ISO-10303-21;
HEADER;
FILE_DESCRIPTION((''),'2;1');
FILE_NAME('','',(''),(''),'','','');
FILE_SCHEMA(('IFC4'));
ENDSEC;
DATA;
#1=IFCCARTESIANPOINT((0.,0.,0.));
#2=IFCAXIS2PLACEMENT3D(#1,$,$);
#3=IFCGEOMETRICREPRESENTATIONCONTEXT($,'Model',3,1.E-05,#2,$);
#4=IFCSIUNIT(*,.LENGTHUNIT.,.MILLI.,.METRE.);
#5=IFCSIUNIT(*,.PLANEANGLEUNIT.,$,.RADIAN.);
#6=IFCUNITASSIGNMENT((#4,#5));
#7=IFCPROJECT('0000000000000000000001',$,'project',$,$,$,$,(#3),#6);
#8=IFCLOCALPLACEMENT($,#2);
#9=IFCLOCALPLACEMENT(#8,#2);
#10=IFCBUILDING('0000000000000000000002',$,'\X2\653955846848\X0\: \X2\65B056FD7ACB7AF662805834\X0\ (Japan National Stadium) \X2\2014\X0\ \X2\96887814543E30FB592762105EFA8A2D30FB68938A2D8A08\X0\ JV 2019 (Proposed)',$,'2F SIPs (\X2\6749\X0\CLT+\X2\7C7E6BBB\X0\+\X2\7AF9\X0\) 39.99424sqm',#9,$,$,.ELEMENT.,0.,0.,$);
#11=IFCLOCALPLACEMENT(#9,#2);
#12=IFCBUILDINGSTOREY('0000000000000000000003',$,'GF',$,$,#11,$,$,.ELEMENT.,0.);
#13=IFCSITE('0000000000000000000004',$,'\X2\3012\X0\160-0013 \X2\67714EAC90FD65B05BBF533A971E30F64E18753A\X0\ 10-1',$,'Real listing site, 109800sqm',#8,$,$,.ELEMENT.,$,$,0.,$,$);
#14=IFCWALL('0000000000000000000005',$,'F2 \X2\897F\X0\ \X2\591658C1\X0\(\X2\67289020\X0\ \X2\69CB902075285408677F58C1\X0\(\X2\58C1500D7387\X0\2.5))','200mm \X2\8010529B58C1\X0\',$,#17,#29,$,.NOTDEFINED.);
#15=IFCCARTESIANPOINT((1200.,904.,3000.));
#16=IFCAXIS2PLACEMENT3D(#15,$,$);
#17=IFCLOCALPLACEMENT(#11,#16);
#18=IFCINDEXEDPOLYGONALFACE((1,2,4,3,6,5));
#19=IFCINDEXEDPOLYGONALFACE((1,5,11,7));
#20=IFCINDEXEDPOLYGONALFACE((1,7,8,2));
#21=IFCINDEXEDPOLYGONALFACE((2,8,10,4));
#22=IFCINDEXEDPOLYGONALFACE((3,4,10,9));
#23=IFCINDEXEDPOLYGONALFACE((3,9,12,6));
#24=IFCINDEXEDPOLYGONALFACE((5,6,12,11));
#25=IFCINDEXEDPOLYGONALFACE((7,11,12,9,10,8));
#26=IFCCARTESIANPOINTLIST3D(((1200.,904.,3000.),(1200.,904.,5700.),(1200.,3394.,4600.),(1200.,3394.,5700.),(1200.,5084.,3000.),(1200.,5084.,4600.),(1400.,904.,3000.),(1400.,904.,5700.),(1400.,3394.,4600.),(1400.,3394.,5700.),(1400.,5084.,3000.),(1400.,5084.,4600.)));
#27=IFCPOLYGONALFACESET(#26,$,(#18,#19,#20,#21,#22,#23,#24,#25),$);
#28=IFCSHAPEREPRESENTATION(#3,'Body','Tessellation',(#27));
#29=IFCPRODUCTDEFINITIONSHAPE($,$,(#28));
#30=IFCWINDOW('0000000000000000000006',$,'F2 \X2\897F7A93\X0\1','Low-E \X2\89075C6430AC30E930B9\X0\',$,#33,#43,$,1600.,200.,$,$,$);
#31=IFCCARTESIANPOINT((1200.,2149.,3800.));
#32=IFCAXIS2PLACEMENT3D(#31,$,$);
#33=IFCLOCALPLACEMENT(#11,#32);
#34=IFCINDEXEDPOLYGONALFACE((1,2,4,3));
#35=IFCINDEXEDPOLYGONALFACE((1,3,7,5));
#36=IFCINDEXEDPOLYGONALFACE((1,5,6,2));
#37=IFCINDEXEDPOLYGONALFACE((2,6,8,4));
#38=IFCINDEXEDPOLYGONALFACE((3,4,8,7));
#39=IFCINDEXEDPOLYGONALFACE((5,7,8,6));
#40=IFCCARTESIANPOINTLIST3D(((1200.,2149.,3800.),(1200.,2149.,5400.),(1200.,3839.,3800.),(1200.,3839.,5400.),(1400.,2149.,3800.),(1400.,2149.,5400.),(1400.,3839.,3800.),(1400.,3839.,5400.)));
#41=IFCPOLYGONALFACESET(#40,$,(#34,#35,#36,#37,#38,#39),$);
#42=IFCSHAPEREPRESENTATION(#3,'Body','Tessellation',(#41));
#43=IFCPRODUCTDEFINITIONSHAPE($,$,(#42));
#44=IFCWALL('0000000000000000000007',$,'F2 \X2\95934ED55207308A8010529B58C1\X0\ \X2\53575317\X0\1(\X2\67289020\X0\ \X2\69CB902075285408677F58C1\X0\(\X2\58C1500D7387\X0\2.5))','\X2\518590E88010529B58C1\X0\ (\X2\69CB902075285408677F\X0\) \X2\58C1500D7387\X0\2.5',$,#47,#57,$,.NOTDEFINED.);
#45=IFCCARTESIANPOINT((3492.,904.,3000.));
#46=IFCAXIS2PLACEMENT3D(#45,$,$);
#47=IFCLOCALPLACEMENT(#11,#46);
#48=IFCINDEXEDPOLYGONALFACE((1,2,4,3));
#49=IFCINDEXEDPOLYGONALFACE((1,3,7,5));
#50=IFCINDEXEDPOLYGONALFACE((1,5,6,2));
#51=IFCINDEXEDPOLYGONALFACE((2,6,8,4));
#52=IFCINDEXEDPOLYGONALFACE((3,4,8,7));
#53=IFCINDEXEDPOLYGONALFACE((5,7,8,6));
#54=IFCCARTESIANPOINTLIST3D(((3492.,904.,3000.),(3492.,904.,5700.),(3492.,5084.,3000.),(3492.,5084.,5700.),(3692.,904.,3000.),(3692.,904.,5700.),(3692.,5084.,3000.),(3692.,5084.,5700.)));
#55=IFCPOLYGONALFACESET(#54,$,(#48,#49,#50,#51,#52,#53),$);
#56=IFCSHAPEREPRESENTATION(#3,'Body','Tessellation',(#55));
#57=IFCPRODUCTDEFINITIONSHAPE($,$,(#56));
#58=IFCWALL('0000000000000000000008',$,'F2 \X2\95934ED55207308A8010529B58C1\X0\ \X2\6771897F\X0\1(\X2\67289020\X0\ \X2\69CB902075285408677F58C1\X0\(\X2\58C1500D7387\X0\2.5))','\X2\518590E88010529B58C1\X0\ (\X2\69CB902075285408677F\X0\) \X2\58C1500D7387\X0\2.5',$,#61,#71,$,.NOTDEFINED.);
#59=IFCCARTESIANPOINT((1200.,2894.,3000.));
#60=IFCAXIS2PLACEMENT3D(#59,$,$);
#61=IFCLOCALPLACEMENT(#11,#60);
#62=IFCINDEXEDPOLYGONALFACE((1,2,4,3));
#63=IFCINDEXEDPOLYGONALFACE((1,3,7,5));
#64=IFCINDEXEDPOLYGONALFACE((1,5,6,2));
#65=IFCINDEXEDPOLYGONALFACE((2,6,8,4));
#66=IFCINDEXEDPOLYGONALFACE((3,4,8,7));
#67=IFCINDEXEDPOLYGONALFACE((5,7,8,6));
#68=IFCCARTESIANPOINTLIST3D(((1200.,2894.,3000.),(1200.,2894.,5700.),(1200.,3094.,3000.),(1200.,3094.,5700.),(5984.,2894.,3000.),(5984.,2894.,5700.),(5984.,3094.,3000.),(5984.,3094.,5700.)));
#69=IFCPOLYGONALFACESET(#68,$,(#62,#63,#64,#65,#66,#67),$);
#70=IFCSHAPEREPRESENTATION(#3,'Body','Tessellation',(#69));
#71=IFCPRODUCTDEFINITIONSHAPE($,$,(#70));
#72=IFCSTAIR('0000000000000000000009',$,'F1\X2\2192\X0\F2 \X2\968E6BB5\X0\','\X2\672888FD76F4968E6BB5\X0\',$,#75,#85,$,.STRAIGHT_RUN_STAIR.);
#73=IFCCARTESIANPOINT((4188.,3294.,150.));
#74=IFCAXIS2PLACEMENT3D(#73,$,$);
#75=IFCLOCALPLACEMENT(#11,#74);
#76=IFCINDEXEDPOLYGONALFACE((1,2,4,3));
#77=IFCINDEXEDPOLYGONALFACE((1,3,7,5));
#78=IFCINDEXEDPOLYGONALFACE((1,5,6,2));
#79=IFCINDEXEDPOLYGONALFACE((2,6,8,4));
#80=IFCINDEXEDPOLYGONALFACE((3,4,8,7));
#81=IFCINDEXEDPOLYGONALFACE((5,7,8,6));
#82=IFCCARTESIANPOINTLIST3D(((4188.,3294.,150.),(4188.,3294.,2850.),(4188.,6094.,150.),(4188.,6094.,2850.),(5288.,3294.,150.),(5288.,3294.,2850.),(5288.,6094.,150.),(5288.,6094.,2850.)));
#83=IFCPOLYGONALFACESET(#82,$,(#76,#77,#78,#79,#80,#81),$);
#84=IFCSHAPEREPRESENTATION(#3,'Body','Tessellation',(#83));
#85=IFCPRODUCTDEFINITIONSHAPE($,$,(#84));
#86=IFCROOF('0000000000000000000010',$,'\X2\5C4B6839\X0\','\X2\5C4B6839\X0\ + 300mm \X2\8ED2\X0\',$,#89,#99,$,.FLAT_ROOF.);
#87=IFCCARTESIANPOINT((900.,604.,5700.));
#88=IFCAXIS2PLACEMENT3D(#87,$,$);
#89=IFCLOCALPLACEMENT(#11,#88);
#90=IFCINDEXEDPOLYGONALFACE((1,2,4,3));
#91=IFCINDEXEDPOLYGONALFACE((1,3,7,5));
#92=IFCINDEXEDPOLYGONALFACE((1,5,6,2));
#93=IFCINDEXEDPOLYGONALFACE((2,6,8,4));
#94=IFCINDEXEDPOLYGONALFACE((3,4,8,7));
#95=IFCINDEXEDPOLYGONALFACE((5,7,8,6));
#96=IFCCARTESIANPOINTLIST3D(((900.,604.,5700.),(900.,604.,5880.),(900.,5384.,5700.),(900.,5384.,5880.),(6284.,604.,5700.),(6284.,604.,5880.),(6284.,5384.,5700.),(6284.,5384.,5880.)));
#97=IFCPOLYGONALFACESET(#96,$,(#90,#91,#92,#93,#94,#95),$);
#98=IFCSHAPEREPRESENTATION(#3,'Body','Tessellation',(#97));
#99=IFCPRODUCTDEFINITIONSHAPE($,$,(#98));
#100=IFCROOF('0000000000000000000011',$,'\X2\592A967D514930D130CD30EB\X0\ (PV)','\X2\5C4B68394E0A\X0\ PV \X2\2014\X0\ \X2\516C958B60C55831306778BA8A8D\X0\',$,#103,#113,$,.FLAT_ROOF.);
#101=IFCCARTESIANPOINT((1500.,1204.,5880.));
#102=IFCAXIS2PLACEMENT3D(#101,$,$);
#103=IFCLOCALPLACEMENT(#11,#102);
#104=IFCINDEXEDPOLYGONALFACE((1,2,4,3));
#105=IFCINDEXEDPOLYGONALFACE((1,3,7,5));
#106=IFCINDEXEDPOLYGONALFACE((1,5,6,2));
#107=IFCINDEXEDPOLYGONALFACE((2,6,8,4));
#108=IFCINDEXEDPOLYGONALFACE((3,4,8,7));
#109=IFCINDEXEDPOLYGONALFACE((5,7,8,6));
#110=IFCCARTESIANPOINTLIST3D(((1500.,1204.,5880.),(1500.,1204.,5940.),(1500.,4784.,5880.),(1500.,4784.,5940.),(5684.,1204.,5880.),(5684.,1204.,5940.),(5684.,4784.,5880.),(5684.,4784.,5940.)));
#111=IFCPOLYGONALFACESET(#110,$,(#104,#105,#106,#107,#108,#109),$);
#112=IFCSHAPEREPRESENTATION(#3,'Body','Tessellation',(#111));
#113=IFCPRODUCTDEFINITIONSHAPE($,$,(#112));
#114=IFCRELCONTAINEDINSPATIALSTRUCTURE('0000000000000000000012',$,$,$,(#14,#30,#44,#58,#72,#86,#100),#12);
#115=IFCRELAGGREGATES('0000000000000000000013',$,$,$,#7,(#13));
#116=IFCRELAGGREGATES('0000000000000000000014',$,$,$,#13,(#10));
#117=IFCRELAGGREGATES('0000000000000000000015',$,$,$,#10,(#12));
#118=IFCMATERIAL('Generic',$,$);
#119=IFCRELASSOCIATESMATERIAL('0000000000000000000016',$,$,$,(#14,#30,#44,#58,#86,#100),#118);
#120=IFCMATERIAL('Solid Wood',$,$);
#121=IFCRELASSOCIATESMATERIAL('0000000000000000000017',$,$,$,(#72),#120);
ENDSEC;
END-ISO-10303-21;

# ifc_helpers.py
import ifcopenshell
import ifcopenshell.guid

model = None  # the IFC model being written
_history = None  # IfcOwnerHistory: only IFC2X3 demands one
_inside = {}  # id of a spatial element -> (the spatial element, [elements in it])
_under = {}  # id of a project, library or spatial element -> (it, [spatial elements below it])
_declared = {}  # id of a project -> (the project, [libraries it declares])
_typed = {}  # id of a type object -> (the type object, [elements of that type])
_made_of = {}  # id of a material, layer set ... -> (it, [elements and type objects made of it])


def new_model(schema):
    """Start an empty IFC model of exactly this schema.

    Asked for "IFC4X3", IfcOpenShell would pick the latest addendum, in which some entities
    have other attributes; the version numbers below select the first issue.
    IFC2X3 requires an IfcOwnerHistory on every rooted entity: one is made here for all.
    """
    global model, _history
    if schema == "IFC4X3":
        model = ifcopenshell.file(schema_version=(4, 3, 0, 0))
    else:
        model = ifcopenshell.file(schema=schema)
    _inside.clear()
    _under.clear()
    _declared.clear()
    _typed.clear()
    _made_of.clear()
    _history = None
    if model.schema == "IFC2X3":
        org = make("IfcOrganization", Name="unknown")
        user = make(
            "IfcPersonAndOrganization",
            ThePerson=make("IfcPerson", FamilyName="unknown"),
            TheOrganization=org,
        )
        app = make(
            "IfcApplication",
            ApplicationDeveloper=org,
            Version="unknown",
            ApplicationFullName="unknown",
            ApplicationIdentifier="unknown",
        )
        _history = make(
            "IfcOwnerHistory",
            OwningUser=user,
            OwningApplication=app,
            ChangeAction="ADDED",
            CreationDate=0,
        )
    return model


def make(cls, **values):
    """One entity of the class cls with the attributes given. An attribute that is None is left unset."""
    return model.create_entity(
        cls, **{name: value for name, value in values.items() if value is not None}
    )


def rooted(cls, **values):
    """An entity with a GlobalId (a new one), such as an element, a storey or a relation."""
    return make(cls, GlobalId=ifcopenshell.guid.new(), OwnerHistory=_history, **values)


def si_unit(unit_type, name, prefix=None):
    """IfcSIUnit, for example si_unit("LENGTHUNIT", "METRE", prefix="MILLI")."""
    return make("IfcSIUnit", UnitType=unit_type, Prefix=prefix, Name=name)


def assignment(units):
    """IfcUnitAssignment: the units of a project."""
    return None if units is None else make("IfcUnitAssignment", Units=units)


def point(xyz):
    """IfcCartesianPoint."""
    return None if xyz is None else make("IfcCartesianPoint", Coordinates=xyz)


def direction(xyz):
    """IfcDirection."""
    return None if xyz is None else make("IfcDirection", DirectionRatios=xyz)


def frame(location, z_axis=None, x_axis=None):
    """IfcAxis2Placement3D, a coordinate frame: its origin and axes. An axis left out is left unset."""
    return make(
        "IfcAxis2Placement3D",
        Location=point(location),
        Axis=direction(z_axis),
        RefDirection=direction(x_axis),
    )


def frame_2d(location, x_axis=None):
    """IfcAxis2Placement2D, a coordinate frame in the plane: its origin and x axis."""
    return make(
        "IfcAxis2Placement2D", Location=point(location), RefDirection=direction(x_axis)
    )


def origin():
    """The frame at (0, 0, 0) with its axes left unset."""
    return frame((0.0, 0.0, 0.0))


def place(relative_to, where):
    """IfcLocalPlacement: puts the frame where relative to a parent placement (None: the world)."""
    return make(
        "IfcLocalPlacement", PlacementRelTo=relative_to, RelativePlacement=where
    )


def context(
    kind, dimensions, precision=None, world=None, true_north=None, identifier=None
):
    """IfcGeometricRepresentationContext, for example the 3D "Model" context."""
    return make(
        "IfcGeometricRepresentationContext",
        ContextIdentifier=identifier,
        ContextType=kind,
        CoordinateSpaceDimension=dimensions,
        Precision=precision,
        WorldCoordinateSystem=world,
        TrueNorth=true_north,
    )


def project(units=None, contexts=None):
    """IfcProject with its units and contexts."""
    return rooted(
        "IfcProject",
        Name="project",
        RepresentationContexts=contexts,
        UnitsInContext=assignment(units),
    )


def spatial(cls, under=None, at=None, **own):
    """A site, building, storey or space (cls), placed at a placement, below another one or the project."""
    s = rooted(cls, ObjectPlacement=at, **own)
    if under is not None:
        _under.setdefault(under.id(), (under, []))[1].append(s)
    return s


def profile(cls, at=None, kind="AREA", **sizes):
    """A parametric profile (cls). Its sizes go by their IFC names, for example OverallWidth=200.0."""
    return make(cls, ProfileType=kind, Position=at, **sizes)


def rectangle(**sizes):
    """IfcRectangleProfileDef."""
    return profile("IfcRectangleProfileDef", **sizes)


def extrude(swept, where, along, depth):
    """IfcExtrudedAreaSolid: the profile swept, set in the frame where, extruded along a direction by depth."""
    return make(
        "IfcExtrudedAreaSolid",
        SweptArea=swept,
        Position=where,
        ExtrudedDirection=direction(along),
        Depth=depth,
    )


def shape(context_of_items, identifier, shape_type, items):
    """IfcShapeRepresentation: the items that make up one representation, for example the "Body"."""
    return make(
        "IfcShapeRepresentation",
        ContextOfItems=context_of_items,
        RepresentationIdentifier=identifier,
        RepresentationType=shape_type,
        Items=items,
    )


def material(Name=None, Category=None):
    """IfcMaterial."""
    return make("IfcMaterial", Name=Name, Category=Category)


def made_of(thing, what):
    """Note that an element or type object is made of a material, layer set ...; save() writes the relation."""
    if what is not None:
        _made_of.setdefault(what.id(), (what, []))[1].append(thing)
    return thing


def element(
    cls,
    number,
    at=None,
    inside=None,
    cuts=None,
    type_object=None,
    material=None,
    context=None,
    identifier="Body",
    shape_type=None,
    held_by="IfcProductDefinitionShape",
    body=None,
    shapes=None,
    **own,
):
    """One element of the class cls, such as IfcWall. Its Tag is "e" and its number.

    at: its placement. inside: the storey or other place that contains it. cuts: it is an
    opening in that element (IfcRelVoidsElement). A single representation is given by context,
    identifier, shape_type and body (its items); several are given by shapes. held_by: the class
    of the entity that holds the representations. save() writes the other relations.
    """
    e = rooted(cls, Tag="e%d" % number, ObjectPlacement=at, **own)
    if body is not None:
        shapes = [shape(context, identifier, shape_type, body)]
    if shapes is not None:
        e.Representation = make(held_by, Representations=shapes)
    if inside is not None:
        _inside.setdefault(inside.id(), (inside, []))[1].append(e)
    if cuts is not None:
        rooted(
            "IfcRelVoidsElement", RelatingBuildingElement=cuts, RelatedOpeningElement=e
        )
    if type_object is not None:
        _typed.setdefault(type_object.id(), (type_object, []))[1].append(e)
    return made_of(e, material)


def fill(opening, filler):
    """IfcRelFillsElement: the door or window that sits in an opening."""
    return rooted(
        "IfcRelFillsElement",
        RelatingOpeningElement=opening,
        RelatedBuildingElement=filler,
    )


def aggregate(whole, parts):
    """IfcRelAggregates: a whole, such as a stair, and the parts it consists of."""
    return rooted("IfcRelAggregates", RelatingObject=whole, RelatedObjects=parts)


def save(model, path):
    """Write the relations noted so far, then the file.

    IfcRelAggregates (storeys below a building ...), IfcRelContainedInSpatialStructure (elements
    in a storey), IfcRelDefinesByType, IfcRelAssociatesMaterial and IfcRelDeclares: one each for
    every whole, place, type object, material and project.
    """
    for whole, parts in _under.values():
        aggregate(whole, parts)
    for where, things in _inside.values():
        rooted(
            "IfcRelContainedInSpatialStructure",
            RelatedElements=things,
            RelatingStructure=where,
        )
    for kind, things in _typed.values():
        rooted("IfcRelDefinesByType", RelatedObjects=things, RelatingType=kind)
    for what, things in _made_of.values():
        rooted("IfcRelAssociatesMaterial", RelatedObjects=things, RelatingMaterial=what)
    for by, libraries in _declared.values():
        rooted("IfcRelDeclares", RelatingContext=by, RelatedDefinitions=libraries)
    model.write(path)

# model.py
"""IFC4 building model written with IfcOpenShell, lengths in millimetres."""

from ifc_helpers import new_model, si_unit, frame, frame_2d, origin, place, context, project, spatial, rectangle, extrude, material, element, fill, save


model = new_model("IFC4")

# Units and contexts
model_context = context("Model", 3, precision=1e-05, world=origin())
ifc_project = project(units=[si_unit("LENGTHUNIT", "METRE", prefix="MILLI"), si_unit("PLANEANGLEUNIT", "RADIAN")], contexts=[model_context])

# Site, building, storey
site_placement = place(None, origin())
site = spatial("IfcSite", under=ifc_project, at=site_placement, Name="〒160-0013 東京都新宿区霞ヶ丘町 10-1", ObjectType="Real listing site, 109800sqm", CompositionType="ELEMENT", RefElevation=0.0)
building_placement = place(site_placement, origin())
building = spatial("IfcBuilding", under=site, at=building_placement, Name="改善案: 新国立競技場 (Japan National Stadium) — 隈研吾・大成建設・梓設計 JV 2019 (Proposed)", ObjectType="2F SIPs (杉CLT+籾殻+竹) 39.99424sqm", CompositionType="ELEMENT", ElevationOfRefHeight=0.0, ElevationOfTerrain=0.0)
storey_placement = place(building_placement, origin())
storey = spatial("IfcBuildingStorey", under=building, at=storey_placement, Name="GF", CompositionType="ELEMENT", Elevation=0.0)

# Shared definitions
ifc_material_1 = material(Name="Generic")

# Shared definitions
ifc_material_2 = material(Name="Solid Wood")

# Wall, opening, window
wall_1_placement = place(storey_placement, frame((1200.0, 904.0, 3000.0)))
wall_1 = element("IfcWall", 1, at=wall_1_placement, inside=storey, material=ifc_material_1, Name="F2 西 外壁(木造 構造用合板壁(壁倍率2.5))", Description="200mm 耐力壁", PredefinedType="NOTDEFINED", context=model_context, shape_type="SweptSolid", body=[
    extrude(rectangle(XDim=200.0, YDim=4180.0, at=frame_2d((100.0, 2090.0))), frame((1200.0, 904.0, 3000.0)), (0.0, 0.0, 1.0), 2700.0),
])
opening_1_placement = place(storey_placement, frame((1200.0, 2149.0, 3800.0)))
opening_1 = element("IfcOpeningElement", 2, at=opening_1_placement, cuts=wall_1, PredefinedType="NOTDEFINED", context=model_context, shape_type="SweptSolid", body=[
    extrude(rectangle(XDim=200.0, YDim=1690.0, at=frame_2d((100.0, 845.0))), frame((1200.0, 2149.0, 3800.0)), (0.0, 0.0, 1.0), 1600.0),
])
window_1_placement = place(storey_placement, frame((1200.0, 2149.0, 3800.0)))
window_1 = element("IfcWindow", 3, at=window_1_placement, inside=storey, material=ifc_material_1, Name="F2 西窓1", Description="Low-E 複層ガラス", OverallHeight=1600.0, OverallWidth=200.0, context=model_context, shape_type="SweptSolid", body=[
    extrude(rectangle(XDim=200.0, YDim=1690.0, at=frame_2d((100.0, 845.0))), frame((1200.0, 2149.0, 3800.0)), (0.0, 0.0, 1.0), 1600.0),
])
fill(opening_1, window_1)

# Walls
wall_2_placement = place(storey_placement, frame((3492.0, 904.0, 3000.0)))
element("IfcWall", 4, at=wall_2_placement, inside=storey, material=ifc_material_1, Name="F2 間仕切り耐力壁 南北1(木造 構造用合板壁(壁倍率2.5))", Description="内部耐力壁 (構造用合板) 壁倍率2.5", PredefinedType="NOTDEFINED", context=model_context, shape_type="SweptSolid", body=[
    extrude(rectangle(XDim=200.0, YDim=4180.0, at=frame_2d((100.0, 2090.0))), frame((3492.0, 904.0, 3000.0)), (0.0, 0.0, 1.0), 2700.0),
])
wall_3_placement = place(storey_placement, frame((1200.0, 2894.0, 3000.0)))
element("IfcWall", 5, at=wall_3_placement, inside=storey, material=ifc_material_1, Name="F2 間仕切り耐力壁 東西1(木造 構造用合板壁(壁倍率2.5))", Description="内部耐力壁 (構造用合板) 壁倍率2.5", PredefinedType="NOTDEFINED", context=model_context, shape_type="SweptSolid", body=[
    extrude(rectangle(XDim=4784.0, YDim=200.0, at=frame_2d((2392.0, 100.0))), frame((1200.0, 2894.0, 3000.0)), (0.0, 0.0, 1.0), 2700.0),
])

# Stair
stair_placement = place(storey_placement, frame((4188.0, 3294.0, 150.0)))
element("IfcStair", 6, at=stair_placement, inside=storey, material=ifc_material_2, Name="F1→F2 階段", Description="木製直階段", PredefinedType="STRAIGHT_RUN_STAIR", context=model_context, shape_type="SweptSolid", body=[
    extrude(rectangle(XDim=1100.0, YDim=2800.0, at=frame_2d((550.0, 1400.0))), frame((4188.0, 3294.0, 150.0)), (0.0, 0.0, 1.0), 2700.0),
])

# Roofs
roof_1_placement = place(storey_placement, frame((900.0, 604.0, 5700.0)))
element("IfcRoof", 7, at=roof_1_placement, inside=storey, material=ifc_material_1, Name="屋根", Description="屋根 + 300mm 軒", PredefinedType="FLAT_ROOF", context=model_context, shape_type="SweptSolid", body=[
    extrude(rectangle(XDim=5384.0, YDim=4780.0, at=frame_2d((2692.0, 2390.0))), frame((900.0, 604.0, 5700.0)), (0.0, 0.0, 1.0), 180.0),
])
roof_2_placement = place(storey_placement, frame((1500.0, 1204.0, 5880.0)))
element("IfcRoof", 8, at=roof_2_placement, inside=storey, material=ifc_material_1, Name="太陽光パネル (PV)", Description="屋根上 PV — 公開情報で確認", PredefinedType="FLAT_ROOF", context=model_context, shape_type="SweptSolid", body=[
    extrude(rectangle(XDim=4184.0, YDim=3580.0, at=frame_2d((2092.0, 1790.0))), frame((1500.0, 1204.0, 5880.0)), (0.0, 0.0, 1.0), 60.0),
])

save(model, "model.ifc")
